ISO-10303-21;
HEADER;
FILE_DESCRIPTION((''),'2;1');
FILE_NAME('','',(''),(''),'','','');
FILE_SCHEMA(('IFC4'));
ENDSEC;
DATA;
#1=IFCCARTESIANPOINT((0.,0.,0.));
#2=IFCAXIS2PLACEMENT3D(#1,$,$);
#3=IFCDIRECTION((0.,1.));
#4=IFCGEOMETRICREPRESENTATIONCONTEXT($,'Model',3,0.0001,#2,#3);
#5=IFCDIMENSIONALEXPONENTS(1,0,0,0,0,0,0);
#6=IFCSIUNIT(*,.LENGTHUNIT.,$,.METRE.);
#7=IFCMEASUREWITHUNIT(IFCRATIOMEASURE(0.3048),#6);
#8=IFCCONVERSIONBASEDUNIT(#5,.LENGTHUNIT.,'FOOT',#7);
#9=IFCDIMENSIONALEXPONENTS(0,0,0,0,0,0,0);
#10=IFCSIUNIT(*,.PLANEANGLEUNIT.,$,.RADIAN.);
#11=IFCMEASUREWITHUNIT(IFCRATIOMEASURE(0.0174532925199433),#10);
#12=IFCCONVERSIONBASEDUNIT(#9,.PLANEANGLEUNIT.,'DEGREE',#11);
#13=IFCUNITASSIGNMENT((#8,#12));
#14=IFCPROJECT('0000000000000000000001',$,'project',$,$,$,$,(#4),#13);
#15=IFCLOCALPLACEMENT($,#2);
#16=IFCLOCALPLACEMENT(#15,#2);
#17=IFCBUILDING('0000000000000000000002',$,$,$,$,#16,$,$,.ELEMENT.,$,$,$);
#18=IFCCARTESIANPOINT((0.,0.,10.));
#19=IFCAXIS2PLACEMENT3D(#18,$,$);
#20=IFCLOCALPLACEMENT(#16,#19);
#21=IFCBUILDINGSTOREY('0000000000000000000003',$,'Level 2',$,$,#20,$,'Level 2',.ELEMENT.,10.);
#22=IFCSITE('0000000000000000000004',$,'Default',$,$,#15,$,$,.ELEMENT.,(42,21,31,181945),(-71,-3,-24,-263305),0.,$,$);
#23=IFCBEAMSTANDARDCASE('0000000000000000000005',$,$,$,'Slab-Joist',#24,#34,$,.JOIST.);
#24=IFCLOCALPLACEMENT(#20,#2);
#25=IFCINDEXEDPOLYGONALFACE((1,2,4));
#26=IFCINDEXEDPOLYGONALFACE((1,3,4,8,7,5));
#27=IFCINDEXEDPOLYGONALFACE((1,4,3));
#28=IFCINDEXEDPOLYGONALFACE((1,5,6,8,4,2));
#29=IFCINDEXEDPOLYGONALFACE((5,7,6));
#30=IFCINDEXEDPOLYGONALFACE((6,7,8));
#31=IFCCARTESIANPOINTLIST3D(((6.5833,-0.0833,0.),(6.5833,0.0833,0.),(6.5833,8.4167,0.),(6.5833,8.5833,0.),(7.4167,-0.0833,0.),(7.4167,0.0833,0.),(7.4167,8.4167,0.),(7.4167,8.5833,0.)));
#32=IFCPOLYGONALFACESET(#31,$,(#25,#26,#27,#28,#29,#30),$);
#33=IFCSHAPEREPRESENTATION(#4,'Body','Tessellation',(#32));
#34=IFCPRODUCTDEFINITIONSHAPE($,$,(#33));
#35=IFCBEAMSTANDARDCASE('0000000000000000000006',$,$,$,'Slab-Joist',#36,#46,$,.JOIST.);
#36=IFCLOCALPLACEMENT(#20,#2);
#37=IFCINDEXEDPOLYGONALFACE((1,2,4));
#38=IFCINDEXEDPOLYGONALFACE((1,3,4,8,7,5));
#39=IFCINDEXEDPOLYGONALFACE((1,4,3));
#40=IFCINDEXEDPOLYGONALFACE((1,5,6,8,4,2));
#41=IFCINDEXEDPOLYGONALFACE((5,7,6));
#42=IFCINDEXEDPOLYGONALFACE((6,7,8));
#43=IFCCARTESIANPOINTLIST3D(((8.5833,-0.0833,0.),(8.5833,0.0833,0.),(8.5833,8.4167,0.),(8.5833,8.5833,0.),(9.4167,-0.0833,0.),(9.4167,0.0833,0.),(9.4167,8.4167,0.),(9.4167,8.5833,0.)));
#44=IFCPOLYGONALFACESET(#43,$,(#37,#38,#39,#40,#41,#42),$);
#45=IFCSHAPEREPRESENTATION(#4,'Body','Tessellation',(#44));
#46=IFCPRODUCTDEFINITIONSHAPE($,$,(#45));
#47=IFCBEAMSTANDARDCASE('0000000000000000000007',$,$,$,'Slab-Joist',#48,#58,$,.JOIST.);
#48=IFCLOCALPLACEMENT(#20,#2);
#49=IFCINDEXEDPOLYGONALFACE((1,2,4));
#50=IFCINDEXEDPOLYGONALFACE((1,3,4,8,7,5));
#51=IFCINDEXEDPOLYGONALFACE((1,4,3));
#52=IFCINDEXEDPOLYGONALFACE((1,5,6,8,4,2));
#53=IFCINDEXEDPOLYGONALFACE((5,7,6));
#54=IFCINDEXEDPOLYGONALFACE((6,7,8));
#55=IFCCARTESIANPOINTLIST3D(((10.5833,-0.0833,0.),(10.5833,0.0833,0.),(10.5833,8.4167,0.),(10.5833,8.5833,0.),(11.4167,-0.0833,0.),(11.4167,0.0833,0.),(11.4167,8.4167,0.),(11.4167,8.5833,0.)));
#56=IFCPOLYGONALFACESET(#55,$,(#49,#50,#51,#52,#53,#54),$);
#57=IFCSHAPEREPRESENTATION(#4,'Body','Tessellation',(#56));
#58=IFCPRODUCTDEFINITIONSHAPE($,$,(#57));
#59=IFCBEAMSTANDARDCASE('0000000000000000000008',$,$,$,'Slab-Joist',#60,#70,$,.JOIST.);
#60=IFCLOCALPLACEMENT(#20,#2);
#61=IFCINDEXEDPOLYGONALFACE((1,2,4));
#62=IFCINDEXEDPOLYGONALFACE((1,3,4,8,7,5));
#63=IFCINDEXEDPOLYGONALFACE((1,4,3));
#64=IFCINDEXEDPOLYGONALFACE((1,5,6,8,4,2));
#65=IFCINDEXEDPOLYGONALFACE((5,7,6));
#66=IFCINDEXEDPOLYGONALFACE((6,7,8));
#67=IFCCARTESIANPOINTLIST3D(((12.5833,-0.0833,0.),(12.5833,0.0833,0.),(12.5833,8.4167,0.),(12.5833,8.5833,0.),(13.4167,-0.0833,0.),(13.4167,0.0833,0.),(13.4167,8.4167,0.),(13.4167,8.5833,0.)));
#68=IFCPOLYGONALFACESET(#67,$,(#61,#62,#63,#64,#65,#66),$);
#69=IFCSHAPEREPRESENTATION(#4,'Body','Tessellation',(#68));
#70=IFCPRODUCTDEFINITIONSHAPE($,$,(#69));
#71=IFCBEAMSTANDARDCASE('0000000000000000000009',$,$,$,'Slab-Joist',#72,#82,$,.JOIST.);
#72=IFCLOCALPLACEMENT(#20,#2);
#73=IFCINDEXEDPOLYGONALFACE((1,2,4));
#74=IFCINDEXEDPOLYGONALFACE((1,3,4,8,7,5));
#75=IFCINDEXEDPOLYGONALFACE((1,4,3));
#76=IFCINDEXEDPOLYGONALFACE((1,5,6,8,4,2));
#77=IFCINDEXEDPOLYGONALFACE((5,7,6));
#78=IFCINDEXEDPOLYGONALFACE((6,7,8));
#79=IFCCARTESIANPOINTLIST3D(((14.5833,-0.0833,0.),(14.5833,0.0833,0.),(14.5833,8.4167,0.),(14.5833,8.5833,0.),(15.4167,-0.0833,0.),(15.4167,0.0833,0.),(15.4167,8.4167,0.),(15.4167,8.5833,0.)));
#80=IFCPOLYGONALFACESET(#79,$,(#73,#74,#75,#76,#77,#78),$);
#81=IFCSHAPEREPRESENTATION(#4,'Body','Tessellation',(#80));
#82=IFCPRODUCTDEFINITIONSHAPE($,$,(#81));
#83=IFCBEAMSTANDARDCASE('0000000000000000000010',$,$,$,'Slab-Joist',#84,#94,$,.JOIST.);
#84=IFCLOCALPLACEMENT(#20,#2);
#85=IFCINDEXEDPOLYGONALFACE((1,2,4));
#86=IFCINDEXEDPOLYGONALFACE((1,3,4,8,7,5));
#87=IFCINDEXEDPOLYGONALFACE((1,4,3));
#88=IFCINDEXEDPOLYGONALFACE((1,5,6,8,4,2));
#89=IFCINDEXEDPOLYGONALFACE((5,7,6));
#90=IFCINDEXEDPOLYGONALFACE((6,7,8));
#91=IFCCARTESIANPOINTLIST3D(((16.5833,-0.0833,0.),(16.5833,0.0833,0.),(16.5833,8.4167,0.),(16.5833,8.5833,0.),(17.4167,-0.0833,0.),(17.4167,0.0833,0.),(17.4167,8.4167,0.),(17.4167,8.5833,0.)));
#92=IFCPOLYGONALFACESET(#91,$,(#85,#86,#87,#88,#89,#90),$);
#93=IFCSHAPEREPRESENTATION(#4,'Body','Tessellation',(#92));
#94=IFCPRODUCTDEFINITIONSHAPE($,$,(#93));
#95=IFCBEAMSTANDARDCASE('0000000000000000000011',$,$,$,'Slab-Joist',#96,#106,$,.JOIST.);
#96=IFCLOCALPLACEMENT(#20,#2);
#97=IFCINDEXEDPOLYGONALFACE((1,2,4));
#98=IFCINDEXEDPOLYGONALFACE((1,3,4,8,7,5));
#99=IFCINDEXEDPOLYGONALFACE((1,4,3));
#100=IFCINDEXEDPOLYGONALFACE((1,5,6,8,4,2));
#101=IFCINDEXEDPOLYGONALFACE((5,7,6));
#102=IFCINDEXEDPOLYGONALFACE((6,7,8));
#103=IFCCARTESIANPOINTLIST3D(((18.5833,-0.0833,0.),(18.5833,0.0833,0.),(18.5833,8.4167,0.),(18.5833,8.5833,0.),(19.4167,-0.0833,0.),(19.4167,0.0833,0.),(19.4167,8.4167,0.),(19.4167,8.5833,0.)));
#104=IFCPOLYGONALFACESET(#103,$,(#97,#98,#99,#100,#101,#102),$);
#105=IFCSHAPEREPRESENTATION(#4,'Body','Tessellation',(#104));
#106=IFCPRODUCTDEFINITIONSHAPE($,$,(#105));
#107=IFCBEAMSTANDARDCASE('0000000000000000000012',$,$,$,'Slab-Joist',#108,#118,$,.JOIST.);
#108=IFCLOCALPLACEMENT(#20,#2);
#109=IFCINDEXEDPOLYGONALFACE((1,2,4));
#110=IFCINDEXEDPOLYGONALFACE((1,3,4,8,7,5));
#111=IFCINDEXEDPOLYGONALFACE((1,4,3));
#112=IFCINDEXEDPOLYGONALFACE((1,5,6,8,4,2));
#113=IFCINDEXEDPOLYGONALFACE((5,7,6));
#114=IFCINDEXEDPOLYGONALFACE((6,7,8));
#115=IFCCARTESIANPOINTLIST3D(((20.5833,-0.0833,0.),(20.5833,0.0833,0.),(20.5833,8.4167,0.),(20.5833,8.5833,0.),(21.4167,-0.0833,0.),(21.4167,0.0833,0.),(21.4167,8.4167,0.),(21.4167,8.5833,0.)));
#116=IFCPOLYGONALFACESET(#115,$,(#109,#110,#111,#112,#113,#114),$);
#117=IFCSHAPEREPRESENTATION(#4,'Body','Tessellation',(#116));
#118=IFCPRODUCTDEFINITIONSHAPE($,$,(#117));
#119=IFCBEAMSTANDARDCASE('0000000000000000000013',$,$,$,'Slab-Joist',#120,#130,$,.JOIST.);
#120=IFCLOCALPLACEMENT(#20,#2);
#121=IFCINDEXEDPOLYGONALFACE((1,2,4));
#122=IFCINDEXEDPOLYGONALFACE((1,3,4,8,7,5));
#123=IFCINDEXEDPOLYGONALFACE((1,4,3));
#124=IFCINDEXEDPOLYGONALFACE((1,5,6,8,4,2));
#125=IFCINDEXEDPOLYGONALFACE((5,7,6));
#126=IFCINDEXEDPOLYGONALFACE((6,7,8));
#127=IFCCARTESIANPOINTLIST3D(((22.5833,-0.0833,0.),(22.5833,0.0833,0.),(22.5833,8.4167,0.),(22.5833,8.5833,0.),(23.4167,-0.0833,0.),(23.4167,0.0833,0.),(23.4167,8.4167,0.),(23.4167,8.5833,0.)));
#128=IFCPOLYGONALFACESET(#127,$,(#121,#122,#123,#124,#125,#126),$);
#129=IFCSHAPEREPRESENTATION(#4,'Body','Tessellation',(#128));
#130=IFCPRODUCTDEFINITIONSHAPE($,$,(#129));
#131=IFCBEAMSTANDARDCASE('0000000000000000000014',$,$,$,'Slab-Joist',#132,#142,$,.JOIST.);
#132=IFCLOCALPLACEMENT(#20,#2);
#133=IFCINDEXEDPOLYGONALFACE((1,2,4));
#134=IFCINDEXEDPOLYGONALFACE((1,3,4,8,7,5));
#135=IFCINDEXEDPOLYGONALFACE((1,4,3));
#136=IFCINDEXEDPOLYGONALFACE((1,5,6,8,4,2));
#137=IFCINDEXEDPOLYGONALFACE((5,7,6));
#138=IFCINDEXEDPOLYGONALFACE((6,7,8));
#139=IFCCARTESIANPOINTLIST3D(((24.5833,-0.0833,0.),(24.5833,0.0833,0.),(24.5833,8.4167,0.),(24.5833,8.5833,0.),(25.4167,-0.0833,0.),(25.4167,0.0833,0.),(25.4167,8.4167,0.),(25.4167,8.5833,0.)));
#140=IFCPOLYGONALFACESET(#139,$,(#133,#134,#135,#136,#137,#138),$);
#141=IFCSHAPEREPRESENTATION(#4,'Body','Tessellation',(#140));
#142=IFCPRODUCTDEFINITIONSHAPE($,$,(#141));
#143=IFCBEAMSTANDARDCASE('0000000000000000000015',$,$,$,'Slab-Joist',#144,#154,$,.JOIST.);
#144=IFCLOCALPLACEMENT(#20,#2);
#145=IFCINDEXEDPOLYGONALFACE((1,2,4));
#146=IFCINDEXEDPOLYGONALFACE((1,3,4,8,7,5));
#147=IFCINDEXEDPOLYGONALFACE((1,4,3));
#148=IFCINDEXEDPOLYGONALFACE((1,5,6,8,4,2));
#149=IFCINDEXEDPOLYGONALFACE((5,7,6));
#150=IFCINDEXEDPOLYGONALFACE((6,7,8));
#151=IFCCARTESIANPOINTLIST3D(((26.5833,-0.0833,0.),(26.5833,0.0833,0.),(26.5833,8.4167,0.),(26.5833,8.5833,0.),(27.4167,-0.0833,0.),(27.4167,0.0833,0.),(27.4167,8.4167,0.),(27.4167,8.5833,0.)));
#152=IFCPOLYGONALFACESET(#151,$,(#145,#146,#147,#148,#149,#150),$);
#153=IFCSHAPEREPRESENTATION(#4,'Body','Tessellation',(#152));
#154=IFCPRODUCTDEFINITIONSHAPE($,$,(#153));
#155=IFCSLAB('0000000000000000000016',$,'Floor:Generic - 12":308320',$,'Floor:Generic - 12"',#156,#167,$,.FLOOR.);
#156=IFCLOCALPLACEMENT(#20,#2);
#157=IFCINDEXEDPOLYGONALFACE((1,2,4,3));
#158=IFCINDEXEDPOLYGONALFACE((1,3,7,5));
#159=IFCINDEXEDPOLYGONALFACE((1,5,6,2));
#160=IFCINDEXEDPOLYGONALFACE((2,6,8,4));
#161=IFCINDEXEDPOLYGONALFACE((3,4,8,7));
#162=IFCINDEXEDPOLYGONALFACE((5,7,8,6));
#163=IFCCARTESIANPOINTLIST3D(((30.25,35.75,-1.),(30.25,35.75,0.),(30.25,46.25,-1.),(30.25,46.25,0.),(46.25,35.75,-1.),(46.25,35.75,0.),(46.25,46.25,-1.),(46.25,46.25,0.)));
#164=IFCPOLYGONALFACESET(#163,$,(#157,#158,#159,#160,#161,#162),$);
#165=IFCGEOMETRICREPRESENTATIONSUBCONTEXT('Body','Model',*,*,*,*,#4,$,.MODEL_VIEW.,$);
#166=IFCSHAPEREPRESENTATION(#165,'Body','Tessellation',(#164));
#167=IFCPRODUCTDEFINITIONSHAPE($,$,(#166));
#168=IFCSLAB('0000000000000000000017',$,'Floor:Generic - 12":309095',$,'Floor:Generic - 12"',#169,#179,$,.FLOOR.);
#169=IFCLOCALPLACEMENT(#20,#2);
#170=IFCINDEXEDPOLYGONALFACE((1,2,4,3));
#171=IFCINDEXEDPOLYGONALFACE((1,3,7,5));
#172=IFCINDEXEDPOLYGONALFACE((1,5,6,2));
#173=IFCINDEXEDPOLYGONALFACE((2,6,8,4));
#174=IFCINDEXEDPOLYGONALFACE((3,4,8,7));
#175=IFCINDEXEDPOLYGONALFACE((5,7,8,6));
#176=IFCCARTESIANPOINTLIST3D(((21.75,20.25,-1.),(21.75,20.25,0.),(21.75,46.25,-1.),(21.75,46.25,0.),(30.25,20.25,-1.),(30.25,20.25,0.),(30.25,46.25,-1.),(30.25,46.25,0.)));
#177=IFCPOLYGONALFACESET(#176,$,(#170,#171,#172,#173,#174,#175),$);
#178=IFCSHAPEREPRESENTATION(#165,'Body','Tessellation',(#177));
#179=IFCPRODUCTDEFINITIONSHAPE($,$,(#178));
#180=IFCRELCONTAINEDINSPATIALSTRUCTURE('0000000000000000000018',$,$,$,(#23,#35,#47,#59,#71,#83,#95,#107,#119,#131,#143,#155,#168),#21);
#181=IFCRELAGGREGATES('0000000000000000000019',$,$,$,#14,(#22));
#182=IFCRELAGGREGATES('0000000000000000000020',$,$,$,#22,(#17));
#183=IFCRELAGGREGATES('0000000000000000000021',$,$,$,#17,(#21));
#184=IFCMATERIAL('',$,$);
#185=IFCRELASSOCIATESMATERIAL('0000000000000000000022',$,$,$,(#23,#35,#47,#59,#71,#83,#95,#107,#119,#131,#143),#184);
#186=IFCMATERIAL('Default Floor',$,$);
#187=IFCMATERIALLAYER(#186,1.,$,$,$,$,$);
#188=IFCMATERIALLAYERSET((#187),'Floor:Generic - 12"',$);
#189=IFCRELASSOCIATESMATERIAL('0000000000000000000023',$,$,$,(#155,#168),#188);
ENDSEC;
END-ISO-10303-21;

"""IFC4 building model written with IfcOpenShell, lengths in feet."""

from ifc_helpers import new_model, entity, si_unit, converted_unit, direction, frame, frame_2d, origin, place, context, subcontext, project, spatial, rectangle, extrude, material, layer, layer_set, layer_usage, element, save


model = new_model("IFC4")

# Units and contexts
model_context = context("Model", 3, precision=0.0001, world=origin(), true_north=direction((0.0, 1.0)))
body_context = subcontext(model_context, "Body", "Model", "MODEL_VIEW")
ifc_project = project(units=[converted_unit("LENGTHUNIT", "FOOT", entity("IfcRatioMeasure", 0.3048), si_unit("LENGTHUNIT", "METRE"), dimensions=[1, 0, 0, 0, 0, 0, 0]), converted_unit("PLANEANGLEUNIT", "DEGREE", entity("IfcRatioMeasure", 0.0174532925199433), si_unit("PLANEANGLEUNIT", "RADIAN"), dimensions=[0, 0, 0, 0, 0, 0, 0])], contexts=[model_context])

# Site, building, storey
site_placement = place(None, origin())
site = spatial("IfcSite", under=ifc_project, at=site_placement, Name="Default", CompositionType="ELEMENT", RefLatitude=(42, 21, 31, 181945), RefLongitude=(-71, -3, -24, -263305), RefElevation=0.0)
building_placement = place(site_placement, origin())
building = spatial("IfcBuilding", under=site, at=building_placement, CompositionType="ELEMENT")
storey_placement = place(building_placement, frame((0.0, 0.0, 10.0)))
storey = spatial("IfcBuildingStorey", under=building, at=storey_placement, Name="Level 2", LongName="Level 2", CompositionType="ELEMENT", Elevation=10.0)

# Beams
ifc_material_1 = material(Name="")
for number, where, z_axis, x_axis in (
    (1, (7.0, 0.0, 0.0), (0.0, 0.0, 1.0), (1.0, 0.0, 0.0)),
    (2, (9.0, 0.0, 0.0), (0.0, 0.0, 1.0), (1.0, 0.0, 0.0)),
    (3, (11.0, 0.0, 0.0), (0.0, 0.0, 1.0), (1.0, 0.0, 0.0)),
    (4, (13.0, 0.0, 0.0), (0.0, 0.0, 1.0), (1.0, 0.0, 0.0)),
    (5, (15.0, 0.0, 0.0), (0.0, 0.0, 1.0), (1.0, 0.0, 0.0)),
    (6, (17.0, 0.0, 0.0), (0.0, 0.0, 1.0), (1.0, 0.0, 0.0)),
    (7, (19.0, 0.0, 0.0), (0.0, 0.0, 1.0), (1.0, 0.0, 0.0)),
    (8, (21.0, 0.0, 0.0), (0.0, 0.0, 1.0), (1.0, 0.0, 0.0)),
    (9, (23.0, 0.0, 0.0), (0.0, 0.0, 1.0), (1.0, 0.0, 0.0)),
    (10, (25.0, 0.0, 0.0), (0.0, 0.0, 1.0), (1.0, 0.0, 0.0)),
    (11, (27.0, 0.0, 0.0), (0.0, 0.0, 1.0), (1.0, 0.0, 0.0)),
):
    element("IfcBeamStandardCase", number, at=place(storey_placement, frame(where, z_axis=z_axis, x_axis=x_axis)), inside=storey, material=ifc_material_1, ObjectType="Slab-Joist", PredefinedType="JOIST", context=model_context, shape_type="SweptSolid", body=[
        extrude(rectangle(XDim=0.1667, YDim=0.8333), frame((0.0, 0.0, 0.0), z_axis=(0.0, 0.0, 1.0), x_axis=(0.0, 1.0, 0.0)), (1.0, 0.0, 0.0), 8.5),
    ])

# Slabs
ifc_material_2 = material(Name="Default Floor")
ifc_layer = layer(ifc_material_2, 1.0)
ifc_layer_set = layer_set([ifc_layer], Name="Floor:Generic - 12\"")
ifc_layer_usage_1 = layer_usage(ifc_layer_set, "AXIS3", "POSITIVE", 0.0)
slab_1_placement = place(storey_placement, origin())
element("IfcSlab", 12, at=slab_1_placement, inside=storey, material=ifc_layer_usage_1, Name="Floor:Generic - 12\":308320", ObjectType="Floor:Generic - 12\"", PredefinedType="FLOOR", context=body_context, shape_type="SweptSolid", body=[
    extrude(rectangle(XDim=10.5, YDim=16.0, at=frame_2d((0.0, 0.0), x_axis=(1.0, 0.0))), frame((38.25, 41.0, 0.0), z_axis=(0.0, 0.0, -1.0), x_axis=(0.0, 1.0, 0.0)), (0.0, 0.0, 1.0), 1.0),
])
ifc_layer_usage_2 = layer_usage(ifc_layer_set, "AXIS3", "POSITIVE", 0.0)
slab_2_placement = place(storey_placement, origin())
element("IfcSlab", 13, at=slab_2_placement, inside=storey, material=ifc_layer_usage_2, Name="Floor:Generic - 12\":309095", ObjectType="Floor:Generic - 12\"", PredefinedType="FLOOR", context=body_context, shape_type="SweptSolid", body=[
    extrude(rectangle(XDim=26.0, YDim=8.5, at=frame_2d((0.0, 0.0), x_axis=(1.0, 0.0))), frame((26.0, 33.25, 0.0), z_axis=(0.0, 0.0, -1.0), x_axis=(0.0, 1.0, 0.0)), (0.0, 0.0, 1.0), 1.0),
])

save(model, "model.ifc")
